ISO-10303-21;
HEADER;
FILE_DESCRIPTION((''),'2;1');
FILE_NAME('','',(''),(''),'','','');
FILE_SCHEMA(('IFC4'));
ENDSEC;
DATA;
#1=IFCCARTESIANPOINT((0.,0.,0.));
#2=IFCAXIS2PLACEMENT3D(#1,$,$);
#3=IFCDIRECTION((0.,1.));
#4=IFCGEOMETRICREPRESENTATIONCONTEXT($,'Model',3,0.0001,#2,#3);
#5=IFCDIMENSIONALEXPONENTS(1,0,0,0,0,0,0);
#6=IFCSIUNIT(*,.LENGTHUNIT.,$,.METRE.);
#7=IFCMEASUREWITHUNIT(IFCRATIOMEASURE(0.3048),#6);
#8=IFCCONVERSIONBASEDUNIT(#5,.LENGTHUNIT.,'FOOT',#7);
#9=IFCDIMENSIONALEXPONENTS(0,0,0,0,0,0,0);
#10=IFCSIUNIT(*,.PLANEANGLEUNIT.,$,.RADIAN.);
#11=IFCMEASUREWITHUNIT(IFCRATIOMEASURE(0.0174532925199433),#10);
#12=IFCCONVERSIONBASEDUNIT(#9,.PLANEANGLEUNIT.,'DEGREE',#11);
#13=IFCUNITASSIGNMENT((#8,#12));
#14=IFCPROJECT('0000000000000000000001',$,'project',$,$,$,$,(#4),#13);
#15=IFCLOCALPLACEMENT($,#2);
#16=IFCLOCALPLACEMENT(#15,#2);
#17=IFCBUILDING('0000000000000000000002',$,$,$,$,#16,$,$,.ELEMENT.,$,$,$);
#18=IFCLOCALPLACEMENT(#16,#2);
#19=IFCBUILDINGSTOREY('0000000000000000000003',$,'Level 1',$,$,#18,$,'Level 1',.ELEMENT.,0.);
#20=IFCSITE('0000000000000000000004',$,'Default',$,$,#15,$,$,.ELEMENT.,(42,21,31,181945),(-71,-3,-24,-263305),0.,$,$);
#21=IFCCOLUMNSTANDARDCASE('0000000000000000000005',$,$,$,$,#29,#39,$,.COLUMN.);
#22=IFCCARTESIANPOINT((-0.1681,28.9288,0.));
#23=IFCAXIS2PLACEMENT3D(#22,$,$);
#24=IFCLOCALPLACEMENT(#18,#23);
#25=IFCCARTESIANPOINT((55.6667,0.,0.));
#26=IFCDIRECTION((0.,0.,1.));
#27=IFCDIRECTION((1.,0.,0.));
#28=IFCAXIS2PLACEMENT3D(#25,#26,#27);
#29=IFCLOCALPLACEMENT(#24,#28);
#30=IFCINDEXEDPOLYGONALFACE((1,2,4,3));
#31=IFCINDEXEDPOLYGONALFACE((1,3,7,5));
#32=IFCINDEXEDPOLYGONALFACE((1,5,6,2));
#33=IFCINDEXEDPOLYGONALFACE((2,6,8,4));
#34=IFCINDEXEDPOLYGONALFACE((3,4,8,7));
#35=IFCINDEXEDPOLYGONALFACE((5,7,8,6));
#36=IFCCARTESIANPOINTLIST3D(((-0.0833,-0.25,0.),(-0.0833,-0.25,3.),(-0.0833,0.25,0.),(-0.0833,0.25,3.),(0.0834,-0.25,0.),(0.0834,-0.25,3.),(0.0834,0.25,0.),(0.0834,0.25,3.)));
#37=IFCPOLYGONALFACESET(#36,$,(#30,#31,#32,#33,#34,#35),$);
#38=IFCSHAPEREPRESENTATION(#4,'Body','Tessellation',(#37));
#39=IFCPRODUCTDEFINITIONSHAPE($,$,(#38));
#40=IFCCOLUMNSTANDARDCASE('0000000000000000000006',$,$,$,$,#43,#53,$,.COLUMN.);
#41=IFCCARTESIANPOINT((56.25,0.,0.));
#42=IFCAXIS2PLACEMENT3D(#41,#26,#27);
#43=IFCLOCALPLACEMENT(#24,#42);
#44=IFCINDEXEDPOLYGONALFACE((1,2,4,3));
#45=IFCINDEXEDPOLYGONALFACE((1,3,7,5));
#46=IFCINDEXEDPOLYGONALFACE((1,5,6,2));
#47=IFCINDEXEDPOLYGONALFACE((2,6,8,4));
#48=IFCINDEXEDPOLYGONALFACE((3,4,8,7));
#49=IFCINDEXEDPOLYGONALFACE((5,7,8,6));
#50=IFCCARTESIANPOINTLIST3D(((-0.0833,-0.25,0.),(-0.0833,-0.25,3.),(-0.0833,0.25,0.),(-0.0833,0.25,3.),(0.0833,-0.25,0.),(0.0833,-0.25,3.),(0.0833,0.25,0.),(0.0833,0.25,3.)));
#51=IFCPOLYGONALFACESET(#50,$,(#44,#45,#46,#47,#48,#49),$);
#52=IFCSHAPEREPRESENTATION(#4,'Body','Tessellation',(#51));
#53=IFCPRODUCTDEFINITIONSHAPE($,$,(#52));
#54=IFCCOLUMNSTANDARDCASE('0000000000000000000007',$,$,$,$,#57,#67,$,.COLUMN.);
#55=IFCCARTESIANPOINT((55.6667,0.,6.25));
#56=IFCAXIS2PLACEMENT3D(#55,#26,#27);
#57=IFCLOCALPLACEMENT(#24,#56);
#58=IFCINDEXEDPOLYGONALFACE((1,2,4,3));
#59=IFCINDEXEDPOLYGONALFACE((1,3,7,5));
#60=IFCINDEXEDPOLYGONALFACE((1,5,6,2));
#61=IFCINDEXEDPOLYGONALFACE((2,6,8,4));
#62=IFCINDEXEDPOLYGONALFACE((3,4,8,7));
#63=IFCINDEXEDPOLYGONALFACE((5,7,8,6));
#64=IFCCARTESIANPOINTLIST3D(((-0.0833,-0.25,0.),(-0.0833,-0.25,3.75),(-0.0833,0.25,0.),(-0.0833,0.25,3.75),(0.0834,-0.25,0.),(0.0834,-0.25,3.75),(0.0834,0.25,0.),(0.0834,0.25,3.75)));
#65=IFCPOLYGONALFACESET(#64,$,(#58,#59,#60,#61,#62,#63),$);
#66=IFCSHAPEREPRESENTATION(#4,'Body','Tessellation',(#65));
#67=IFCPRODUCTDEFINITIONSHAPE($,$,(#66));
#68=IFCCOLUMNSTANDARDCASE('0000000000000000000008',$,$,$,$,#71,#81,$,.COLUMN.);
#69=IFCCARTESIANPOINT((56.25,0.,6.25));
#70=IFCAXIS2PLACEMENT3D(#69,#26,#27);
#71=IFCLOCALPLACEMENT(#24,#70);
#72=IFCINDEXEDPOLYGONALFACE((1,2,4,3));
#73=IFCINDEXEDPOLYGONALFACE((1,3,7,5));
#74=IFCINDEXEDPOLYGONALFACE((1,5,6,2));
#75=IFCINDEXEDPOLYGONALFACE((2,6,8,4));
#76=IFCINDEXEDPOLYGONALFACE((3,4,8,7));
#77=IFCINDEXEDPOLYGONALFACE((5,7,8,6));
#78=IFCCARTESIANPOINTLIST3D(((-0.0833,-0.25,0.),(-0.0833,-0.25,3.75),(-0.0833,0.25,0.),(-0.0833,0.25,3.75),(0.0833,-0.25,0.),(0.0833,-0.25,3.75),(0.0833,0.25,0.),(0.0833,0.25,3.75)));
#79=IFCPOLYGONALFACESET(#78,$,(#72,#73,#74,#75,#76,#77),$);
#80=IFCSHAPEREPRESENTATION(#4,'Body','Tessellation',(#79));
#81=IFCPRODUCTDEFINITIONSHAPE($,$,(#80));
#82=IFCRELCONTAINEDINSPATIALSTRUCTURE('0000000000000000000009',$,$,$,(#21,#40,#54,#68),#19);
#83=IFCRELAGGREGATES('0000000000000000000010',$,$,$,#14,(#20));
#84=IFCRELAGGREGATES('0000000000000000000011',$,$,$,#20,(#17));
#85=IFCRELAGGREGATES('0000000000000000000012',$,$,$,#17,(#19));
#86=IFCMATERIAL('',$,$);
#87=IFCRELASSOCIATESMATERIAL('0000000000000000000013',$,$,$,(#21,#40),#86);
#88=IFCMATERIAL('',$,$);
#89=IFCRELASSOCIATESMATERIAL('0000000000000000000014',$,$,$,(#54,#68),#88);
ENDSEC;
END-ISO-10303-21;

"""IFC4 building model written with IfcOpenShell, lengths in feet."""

from ifc_helpers import new_model, entity, si_unit, converted_unit, direction, frame, origin, place, context, project, spatial, rectangle, extrude, material, element, save


model = new_model("IFC4")

# Units and contexts
model_context = context("Model", 3, precision=0.0001, world=origin(), true_north=direction((0.0, 1.0)))
ifc_project = project(units=[converted_unit("LENGTHUNIT", "FOOT", entity("IfcRatioMeasure", 0.3048), si_unit("LENGTHUNIT", "METRE"), dimensions=[1, 0, 0, 0, 0, 0, 0]), converted_unit("PLANEANGLEUNIT", "DEGREE", entity("IfcRatioMeasure", 0.0174532925199433), si_unit("PLANEANGLEUNIT", "RADIAN"), dimensions=[0, 0, 0, 0, 0, 0, 0])], contexts=[model_context])

# Site, building, storey
site_placement = place(None, origin())
site = spatial("IfcSite", under=ifc_project, at=site_placement, Name="Default", CompositionType="ELEMENT", RefLatitude=(42, 21, 31, 181945), RefLongitude=(-71, -3, -24, -263305), RefElevation=0.0)
building_placement = place(site_placement, origin())
building = spatial("IfcBuilding", under=site, at=building_placement, CompositionType="ELEMENT")
storey_placement = place(building_placement, origin())
storey = spatial("IfcBuildingStorey", under=building, at=storey_placement, Name="Level 1", LongName="Level 1", CompositionType="ELEMENT", Elevation=0.0)

# Columns
ifc_material_1 = material(Name="")
placement = place(storey_placement, frame((-0.1681, 28.9288, 0.0)))
for number, where, z_axis, x_axis in (
    (1, (55.6667, 0.0, 0.0), (0.0, 0.0, 1.0), (1.0, 0.0, 0.0)),
    (2, (56.25, 0.0, 0.0), (0.0, 0.0, 1.0), (1.0, 0.0, 0.0)),
):
    element("IfcColumnStandardCase", number, at=place(placement, frame(where, z_axis=z_axis, x_axis=x_axis)), inside=storey, material=ifc_material_1, PredefinedType="COLUMN", context=model_context, shape_type="SweptSolid", body=[
        extrude(rectangle(XDim=0.1667, YDim=0.5), origin(), (0.0, 0.0, 1.0), 3.0),
    ])
ifc_material_2 = material(Name="")
for number, where, z_axis, x_axis in (
    (3, (55.6667, 0.0, 6.25), (0.0, 0.0, 1.0), (1.0, 0.0, 0.0)),
    (4, (56.25, 0.0, 6.25), (0.0, 0.0, 1.0), (1.0, 0.0, 0.0)),
):
    element("IfcColumnStandardCase", number, at=place(placement, frame(where, z_axis=z_axis, x_axis=x_axis)), inside=storey, material=ifc_material_2, PredefinedType="COLUMN", context=model_context, shape_type="SweptSolid", body=[
        extrude(rectangle(XDim=0.1667, YDim=0.5), origin(), (0.0, 0.0, 1.0), 3.75),
    ])

save(model, "model.ifc")
